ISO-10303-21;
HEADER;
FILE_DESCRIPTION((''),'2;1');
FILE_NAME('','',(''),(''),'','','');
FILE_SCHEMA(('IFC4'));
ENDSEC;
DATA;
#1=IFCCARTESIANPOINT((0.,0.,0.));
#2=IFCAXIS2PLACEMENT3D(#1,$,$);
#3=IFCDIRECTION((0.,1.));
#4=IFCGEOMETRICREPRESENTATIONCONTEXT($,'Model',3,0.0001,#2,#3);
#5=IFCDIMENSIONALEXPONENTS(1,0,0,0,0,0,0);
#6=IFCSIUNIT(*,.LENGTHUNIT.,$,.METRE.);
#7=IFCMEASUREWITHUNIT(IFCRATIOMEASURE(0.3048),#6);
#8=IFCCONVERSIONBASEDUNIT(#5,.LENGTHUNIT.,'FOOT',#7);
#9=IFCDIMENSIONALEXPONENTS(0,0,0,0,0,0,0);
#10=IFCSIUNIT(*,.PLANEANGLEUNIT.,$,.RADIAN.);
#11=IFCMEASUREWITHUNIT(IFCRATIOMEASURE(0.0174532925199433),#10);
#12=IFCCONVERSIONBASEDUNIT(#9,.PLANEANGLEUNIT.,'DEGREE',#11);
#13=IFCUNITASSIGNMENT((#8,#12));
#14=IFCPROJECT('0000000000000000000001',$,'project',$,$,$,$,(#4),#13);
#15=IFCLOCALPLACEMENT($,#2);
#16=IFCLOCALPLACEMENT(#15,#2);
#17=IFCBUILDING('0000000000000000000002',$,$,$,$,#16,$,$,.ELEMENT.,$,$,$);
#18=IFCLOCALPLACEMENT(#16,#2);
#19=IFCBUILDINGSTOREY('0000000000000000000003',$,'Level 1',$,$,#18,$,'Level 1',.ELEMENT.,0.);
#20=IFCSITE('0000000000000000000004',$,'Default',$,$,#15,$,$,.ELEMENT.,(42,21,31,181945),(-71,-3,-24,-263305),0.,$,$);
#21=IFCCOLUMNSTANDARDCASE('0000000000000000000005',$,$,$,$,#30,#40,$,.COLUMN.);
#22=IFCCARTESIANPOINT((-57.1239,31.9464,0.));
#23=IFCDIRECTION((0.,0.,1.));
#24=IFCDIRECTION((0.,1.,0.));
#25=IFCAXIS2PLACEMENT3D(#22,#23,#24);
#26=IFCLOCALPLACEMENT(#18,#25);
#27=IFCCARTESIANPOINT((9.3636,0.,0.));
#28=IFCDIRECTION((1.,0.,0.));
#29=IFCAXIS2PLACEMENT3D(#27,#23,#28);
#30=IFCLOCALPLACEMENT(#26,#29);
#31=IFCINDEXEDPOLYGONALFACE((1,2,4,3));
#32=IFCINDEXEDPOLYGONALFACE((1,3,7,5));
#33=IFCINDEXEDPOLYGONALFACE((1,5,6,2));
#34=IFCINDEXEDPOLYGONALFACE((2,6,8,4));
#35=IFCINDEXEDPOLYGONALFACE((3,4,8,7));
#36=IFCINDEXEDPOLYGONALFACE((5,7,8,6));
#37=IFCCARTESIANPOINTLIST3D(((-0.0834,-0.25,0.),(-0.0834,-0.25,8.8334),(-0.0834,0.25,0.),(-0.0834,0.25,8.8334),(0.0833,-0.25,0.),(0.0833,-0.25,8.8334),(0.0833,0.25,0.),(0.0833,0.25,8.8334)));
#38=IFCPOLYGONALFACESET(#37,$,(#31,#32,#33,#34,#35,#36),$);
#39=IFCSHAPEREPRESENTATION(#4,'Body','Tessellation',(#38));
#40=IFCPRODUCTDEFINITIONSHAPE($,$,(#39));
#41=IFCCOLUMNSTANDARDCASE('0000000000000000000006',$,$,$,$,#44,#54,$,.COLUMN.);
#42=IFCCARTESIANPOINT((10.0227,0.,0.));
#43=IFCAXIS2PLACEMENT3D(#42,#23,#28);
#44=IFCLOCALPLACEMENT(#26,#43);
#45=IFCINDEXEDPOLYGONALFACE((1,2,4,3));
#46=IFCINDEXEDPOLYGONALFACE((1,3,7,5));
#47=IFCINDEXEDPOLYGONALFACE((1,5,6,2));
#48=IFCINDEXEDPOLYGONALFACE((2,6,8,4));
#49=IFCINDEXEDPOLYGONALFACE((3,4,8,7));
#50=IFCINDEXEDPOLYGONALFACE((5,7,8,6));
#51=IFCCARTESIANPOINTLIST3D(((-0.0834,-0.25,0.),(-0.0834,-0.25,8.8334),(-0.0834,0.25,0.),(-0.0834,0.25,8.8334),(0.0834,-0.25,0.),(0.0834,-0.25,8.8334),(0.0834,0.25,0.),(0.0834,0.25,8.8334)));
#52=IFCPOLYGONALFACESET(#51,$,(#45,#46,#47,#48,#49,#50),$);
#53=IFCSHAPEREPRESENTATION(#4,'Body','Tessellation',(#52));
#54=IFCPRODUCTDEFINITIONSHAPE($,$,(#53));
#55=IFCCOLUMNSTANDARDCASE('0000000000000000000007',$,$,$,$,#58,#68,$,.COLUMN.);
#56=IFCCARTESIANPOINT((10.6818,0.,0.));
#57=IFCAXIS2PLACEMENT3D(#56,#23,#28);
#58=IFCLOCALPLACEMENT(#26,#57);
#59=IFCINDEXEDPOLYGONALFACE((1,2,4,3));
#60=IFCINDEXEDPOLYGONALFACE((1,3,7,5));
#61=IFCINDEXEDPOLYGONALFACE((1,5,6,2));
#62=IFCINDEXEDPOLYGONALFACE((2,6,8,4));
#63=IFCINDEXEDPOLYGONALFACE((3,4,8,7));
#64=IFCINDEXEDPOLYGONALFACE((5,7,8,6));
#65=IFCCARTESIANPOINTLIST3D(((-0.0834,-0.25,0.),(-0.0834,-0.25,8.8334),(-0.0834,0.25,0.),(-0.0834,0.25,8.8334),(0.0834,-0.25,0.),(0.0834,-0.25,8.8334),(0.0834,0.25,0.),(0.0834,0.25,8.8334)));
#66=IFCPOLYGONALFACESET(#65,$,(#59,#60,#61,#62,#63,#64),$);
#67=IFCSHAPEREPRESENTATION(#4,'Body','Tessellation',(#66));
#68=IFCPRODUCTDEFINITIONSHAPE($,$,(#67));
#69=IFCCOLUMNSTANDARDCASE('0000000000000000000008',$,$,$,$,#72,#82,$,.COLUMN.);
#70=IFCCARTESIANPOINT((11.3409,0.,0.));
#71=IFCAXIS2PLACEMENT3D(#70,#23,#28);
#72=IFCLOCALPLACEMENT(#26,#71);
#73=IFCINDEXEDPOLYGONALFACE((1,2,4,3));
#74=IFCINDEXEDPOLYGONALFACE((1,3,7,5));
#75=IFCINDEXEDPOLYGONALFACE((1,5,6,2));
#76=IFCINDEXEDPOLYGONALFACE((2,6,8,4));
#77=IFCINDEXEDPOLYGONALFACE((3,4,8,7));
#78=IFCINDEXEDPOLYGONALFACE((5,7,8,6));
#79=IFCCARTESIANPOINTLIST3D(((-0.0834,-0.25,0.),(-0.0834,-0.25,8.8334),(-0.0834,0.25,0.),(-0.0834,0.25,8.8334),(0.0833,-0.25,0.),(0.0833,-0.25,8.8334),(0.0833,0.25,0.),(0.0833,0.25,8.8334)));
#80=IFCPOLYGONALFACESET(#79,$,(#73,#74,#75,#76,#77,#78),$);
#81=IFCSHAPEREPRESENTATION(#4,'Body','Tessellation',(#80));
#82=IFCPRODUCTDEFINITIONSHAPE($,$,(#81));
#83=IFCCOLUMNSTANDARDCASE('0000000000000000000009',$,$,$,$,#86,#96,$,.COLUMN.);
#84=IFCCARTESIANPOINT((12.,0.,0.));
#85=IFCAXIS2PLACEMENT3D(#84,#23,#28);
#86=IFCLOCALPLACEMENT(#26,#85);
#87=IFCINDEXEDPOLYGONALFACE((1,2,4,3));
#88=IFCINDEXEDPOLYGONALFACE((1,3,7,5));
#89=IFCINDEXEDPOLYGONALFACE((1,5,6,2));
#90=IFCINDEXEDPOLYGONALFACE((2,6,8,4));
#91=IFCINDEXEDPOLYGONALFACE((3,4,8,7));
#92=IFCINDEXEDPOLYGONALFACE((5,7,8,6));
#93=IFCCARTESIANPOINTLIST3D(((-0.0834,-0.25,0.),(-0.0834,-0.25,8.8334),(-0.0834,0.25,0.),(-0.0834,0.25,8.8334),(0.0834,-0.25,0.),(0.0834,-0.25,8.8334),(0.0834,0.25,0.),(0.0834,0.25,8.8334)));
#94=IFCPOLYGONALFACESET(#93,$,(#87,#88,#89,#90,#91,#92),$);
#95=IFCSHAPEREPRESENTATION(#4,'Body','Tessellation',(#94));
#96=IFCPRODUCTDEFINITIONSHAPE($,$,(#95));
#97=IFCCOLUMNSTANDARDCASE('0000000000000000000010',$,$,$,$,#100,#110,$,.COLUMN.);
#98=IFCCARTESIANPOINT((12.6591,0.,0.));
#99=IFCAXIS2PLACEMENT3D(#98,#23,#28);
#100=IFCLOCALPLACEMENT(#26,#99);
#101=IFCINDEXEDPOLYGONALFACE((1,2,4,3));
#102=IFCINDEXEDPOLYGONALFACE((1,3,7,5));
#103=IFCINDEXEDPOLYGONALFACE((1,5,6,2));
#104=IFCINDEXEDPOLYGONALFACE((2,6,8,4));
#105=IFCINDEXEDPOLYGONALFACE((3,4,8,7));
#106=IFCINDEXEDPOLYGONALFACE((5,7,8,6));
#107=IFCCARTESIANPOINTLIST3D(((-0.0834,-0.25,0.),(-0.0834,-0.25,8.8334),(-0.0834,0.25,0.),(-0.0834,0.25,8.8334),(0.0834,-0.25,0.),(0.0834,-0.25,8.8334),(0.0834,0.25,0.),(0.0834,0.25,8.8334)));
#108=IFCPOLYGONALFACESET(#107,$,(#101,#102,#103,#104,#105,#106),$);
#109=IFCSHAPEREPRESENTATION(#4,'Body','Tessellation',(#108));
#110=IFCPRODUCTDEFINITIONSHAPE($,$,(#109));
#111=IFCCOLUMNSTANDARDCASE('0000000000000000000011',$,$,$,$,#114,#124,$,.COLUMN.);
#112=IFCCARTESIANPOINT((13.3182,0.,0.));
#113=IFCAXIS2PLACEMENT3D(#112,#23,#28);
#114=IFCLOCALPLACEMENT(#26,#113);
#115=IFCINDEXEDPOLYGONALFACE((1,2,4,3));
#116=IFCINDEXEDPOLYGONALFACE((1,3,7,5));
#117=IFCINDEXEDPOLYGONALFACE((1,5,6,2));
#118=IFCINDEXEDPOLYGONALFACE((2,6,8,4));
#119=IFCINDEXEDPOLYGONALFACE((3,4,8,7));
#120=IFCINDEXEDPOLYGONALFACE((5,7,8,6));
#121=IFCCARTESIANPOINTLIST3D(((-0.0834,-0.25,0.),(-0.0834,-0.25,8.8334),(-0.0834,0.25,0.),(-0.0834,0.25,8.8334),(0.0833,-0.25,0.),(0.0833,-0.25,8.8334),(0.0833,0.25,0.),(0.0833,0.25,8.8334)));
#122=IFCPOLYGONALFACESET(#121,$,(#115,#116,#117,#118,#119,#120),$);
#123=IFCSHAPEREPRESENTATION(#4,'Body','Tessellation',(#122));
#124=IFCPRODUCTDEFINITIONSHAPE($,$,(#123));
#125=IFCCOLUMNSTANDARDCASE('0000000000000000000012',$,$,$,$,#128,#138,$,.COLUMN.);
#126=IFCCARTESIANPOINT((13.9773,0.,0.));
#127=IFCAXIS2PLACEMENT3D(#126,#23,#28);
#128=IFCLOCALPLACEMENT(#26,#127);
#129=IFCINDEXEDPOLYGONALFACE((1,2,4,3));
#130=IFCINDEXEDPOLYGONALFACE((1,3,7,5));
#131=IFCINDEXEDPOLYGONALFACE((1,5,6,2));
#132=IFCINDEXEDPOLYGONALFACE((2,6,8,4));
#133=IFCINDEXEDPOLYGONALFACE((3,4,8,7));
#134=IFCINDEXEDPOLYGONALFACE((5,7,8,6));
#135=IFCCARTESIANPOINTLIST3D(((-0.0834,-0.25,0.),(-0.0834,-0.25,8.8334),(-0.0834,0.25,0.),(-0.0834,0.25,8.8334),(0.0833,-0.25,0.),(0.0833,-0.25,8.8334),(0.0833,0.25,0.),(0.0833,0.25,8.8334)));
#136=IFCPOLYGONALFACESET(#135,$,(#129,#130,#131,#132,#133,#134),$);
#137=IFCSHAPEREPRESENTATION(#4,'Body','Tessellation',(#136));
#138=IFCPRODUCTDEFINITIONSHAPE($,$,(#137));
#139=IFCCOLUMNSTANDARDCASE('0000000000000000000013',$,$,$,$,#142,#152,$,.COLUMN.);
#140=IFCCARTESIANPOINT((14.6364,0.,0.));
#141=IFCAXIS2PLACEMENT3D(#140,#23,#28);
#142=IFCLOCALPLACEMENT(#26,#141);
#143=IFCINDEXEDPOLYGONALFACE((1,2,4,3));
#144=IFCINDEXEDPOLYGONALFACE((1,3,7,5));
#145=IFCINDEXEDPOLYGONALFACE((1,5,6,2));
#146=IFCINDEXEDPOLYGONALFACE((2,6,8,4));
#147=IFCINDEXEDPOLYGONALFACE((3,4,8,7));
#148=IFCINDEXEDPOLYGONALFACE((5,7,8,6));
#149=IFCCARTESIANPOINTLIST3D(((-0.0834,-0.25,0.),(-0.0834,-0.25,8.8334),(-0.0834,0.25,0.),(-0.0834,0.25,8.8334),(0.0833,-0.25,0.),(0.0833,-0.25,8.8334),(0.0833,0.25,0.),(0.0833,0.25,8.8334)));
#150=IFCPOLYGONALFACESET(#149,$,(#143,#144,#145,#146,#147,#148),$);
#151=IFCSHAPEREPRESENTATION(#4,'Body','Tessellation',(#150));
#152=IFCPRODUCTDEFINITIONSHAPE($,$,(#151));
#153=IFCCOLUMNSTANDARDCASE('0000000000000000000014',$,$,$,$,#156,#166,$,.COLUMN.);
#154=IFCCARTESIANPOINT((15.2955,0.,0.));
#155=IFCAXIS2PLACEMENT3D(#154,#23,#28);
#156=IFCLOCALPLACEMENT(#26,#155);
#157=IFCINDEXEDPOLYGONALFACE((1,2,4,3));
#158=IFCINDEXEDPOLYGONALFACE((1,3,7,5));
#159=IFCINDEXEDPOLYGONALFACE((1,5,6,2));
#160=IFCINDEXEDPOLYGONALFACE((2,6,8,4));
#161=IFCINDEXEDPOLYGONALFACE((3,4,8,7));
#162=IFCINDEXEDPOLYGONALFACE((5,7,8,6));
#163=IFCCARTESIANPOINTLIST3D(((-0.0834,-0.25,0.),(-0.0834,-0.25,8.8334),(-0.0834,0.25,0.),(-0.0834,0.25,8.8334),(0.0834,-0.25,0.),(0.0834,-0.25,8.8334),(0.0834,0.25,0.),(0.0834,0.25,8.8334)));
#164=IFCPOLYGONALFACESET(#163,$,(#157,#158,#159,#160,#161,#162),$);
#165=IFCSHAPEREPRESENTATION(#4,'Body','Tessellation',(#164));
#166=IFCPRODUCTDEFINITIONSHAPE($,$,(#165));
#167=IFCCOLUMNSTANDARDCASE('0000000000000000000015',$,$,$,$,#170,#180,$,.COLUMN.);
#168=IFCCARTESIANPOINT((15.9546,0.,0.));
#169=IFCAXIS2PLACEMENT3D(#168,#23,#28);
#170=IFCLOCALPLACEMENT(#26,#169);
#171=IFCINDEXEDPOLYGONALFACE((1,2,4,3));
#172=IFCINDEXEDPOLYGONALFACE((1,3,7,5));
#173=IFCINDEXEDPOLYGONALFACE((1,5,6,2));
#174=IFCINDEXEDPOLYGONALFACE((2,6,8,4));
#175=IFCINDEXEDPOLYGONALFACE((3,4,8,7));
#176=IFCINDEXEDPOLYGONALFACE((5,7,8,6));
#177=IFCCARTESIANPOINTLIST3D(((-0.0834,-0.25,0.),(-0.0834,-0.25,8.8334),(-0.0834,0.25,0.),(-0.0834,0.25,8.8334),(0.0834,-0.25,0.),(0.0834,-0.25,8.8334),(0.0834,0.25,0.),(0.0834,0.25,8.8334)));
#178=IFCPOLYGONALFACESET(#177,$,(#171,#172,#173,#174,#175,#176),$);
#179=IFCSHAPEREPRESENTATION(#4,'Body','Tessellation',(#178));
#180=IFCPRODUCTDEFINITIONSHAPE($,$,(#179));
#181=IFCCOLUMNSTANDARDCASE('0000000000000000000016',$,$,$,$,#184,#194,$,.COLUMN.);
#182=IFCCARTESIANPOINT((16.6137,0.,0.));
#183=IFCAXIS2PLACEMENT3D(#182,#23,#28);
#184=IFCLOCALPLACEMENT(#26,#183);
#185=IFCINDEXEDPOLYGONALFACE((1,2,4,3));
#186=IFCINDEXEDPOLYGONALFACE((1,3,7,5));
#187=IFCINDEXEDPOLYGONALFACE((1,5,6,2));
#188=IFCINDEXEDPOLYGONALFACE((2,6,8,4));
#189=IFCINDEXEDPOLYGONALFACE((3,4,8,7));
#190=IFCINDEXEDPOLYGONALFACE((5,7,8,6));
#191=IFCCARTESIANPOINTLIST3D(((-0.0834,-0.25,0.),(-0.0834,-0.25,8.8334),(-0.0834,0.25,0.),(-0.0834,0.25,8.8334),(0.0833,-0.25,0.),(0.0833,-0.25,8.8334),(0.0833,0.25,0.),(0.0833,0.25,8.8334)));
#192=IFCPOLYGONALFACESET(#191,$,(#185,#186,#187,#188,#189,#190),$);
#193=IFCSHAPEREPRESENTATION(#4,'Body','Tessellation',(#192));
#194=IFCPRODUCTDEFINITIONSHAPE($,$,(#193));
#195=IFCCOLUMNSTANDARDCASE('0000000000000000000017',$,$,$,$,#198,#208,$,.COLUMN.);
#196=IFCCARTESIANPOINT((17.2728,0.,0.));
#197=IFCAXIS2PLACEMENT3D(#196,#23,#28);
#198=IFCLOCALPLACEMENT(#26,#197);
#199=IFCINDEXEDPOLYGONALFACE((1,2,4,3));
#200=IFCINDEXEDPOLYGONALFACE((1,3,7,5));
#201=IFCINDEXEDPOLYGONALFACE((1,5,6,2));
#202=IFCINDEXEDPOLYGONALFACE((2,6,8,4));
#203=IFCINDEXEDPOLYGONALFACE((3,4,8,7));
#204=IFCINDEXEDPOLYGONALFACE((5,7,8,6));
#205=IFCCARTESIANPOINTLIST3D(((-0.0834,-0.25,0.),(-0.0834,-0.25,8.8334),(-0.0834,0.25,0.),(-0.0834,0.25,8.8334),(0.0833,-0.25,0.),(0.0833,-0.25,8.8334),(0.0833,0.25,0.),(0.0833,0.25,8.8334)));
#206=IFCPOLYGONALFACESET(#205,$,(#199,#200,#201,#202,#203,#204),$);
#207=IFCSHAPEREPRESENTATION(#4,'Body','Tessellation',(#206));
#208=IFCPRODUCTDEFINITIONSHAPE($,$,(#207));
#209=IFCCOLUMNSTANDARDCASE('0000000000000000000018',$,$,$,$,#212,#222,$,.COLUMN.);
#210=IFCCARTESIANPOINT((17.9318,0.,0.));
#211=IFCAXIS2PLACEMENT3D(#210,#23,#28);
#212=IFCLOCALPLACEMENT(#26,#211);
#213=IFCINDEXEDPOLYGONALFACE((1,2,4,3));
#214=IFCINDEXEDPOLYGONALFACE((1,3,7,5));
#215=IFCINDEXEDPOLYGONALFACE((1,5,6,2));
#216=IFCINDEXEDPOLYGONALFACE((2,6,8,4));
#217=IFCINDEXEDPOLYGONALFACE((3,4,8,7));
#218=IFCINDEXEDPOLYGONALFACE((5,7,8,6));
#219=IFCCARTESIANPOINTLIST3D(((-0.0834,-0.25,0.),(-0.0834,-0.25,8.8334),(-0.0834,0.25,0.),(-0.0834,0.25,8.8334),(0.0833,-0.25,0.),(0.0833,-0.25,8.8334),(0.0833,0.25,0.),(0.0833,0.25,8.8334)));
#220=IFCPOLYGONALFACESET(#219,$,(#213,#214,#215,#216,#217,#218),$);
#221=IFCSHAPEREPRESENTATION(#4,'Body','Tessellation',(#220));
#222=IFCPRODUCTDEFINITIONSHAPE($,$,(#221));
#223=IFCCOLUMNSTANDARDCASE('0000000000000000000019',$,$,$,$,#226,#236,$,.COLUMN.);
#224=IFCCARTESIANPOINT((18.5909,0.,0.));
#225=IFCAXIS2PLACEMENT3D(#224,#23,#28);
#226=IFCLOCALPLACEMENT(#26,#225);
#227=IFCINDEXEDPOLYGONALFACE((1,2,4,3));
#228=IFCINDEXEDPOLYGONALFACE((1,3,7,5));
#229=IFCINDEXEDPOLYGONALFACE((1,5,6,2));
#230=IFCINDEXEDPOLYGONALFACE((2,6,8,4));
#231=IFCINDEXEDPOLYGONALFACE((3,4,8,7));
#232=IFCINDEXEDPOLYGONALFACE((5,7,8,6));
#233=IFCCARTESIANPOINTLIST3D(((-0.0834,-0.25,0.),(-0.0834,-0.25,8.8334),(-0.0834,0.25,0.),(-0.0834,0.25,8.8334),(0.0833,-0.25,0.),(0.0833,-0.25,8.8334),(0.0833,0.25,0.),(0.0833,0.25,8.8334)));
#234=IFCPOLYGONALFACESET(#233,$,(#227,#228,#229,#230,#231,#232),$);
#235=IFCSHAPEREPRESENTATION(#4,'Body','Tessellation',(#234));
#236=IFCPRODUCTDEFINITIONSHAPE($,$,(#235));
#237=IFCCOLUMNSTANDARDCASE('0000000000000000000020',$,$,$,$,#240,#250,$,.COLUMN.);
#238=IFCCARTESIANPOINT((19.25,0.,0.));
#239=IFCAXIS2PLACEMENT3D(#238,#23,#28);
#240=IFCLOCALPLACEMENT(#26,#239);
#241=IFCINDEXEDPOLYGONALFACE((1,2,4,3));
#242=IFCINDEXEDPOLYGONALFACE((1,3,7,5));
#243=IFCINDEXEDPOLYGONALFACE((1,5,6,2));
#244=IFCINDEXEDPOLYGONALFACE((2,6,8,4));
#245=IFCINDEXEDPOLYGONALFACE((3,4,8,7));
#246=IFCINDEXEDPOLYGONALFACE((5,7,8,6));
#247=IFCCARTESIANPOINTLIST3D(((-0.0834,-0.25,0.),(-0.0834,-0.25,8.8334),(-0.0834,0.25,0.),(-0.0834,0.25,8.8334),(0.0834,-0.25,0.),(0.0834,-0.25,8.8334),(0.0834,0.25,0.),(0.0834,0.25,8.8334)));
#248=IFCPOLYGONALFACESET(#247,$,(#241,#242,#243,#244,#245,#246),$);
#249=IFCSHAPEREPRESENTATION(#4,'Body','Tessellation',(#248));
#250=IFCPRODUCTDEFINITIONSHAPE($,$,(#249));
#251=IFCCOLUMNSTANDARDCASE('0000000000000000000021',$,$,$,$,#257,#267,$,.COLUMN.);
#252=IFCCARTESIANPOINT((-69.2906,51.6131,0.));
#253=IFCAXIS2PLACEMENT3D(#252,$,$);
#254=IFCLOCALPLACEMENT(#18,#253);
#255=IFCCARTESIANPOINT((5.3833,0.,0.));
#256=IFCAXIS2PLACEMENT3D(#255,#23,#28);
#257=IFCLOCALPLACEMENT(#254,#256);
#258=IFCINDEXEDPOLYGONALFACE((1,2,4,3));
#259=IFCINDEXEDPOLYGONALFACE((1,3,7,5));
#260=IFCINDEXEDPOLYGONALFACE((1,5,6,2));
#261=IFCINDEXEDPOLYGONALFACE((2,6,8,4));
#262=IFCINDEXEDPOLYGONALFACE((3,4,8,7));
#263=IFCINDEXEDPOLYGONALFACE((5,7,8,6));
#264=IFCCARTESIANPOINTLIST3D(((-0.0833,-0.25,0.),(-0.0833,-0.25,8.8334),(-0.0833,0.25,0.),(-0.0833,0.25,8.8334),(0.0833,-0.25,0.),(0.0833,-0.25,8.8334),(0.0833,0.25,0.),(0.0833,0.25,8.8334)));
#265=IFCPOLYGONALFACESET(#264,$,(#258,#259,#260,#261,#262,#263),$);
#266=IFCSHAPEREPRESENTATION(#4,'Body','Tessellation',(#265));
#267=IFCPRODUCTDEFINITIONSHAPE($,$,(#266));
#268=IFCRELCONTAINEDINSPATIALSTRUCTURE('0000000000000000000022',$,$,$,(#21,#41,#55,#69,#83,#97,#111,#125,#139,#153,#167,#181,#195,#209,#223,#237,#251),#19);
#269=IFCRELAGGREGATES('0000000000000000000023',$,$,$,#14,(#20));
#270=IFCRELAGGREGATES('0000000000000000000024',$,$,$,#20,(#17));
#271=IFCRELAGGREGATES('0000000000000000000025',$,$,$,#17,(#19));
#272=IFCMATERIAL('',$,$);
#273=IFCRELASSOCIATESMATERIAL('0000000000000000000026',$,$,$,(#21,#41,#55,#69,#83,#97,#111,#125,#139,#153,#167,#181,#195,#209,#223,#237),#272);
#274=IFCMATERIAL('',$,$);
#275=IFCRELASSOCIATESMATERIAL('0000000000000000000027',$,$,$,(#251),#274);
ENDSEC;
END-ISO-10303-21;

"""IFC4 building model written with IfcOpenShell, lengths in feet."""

from ifc_helpers import new_model, entity, si_unit, converted_unit, direction, frame, origin, place, context, project, spatial, rectangle, extrude, material, element, save


model = new_model("IFC4")

# Units and contexts
model_context = context("Model", 3, precision=0.0001, world=origin(), true_north=direction((0.0, 1.0)))
ifc_project = project(units=[converted_unit("LENGTHUNIT", "FOOT", entity("IfcRatioMeasure", 0.3048), si_unit("LENGTHUNIT", "METRE"), dimensions=[1, 0, 0, 0, 0, 0, 0]), converted_unit("PLANEANGLEUNIT", "DEGREE", entity("IfcRatioMeasure", 0.0174532925199433), si_unit("PLANEANGLEUNIT", "RADIAN"), dimensions=[0, 0, 0, 0, 0, 0, 0])], contexts=[model_context])

# Site, building, storey
site_placement = place(None, origin())
site = spatial("IfcSite", under=ifc_project, at=site_placement, Name="Default", CompositionType="ELEMENT", RefLatitude=(42, 21, 31, 181945), RefLongitude=(-71, -3, -24, -263305), RefElevation=0.0)
building_placement = place(site_placement, origin())
building = spatial("IfcBuilding", under=site, at=building_placement, CompositionType="ELEMENT")
storey_placement = place(building_placement, origin())
storey = spatial("IfcBuildingStorey", under=building, at=storey_placement, Name="Level 1", LongName="Level 1", CompositionType="ELEMENT", Elevation=0.0)

# Columns
ifc_material_1 = material(Name="")
placement_1 = place(storey_placement, frame((-57.1239, 31.9464, 0.0), z_axis=(0.0, 0.0, 1.0), x_axis=(0.0, 1.0, 0.0)))
for number, where, z_axis, x_axis in (
    (1, (9.3636, 0.0, 0.0), (0.0, 0.0, 1.0), (1.0, 0.0, 0.0)),
    (2, (10.0227, 0.0, 0.0), (0.0, 0.0, 1.0), (1.0, 0.0, 0.0)),
    (3, (10.6818, 0.0, 0.0), (0.0, 0.0, 1.0), (1.0, 0.0, 0.0)),
    (4, (11.3409, 0.0, 0.0), (0.0, 0.0, 1.0), (1.0, 0.0, 0.0)),
    (5, (12.0, 0.0, 0.0), (0.0, 0.0, 1.0), (1.0, 0.0, 0.0)),
    (6, (12.6591, 0.0, 0.0), (0.0, 0.0, 1.0), (1.0, 0.0, 0.0)),
    (7, (13.3182, 0.0, 0.0), (0.0, 0.0, 1.0), (1.0, 0.0, 0.0)),
    (8, (13.9773, 0.0, 0.0), (0.0, 0.0, 1.0), (1.0, 0.0, 0.0)),
    (9, (14.6364, 0.0, 0.0), (0.0, 0.0, 1.0), (1.0, 0.0, 0.0)),
    (10, (15.2955, 0.0, 0.0), (0.0, 0.0, 1.0), (1.0, 0.0, 0.0)),
    (11, (15.9546, 0.0, 0.0), (0.0, 0.0, 1.0), (1.0, 0.0, 0.0)),
    (12, (16.6137, 0.0, 0.0), (0.0, 0.0, 1.0), (1.0, 0.0, 0.0)),
    (13, (17.2728, 0.0, 0.0), (0.0, 0.0, 1.0), (1.0, 0.0, 0.0)),
    (14, (17.9318, 0.0, 0.0), (0.0, 0.0, 1.0), (1.0, 0.0, 0.0)),
    (15, (18.5909, 0.0, 0.0), (0.0, 0.0, 1.0), (1.0, 0.0, 0.0)),
    (16, (19.25, 0.0, 0.0), (0.0, 0.0, 1.0), (1.0, 0.0, 0.0)),
):
    element("IfcColumnStandardCase", number, at=place(placement_1, frame(where, z_axis=z_axis, x_axis=x_axis)), inside=storey, material=ifc_material_1, PredefinedType="COLUMN", context=model_context, shape_type="SweptSolid", body=[
        extrude(rectangle(XDim=0.1667, YDim=0.5), origin(), (0.0, 0.0, 1.0), 8.8334),
    ])
ifc_material_2 = material(Name="")
placement_2 = place(storey_placement, frame((-69.2906, 51.6131, 0.0)))
for number, where, z_axis, x_axis in (
    (17, (5.3833, 0.0, 0.0), (0.0, 0.0, 1.0), (1.0, 0.0, 0.0)),
):
    element("IfcColumnStandardCase", number, at=place(placement_2, frame(where, z_axis=z_axis, x_axis=x_axis)), inside=storey, material=ifc_material_2, PredefinedType="COLUMN", context=model_context, shape_type="SweptSolid", body=[
        extrude(rectangle(XDim=0.1667, YDim=0.5), origin(), (0.0, 0.0, 1.0), 8.8334),
    ])

save(model, "model.ifc")
